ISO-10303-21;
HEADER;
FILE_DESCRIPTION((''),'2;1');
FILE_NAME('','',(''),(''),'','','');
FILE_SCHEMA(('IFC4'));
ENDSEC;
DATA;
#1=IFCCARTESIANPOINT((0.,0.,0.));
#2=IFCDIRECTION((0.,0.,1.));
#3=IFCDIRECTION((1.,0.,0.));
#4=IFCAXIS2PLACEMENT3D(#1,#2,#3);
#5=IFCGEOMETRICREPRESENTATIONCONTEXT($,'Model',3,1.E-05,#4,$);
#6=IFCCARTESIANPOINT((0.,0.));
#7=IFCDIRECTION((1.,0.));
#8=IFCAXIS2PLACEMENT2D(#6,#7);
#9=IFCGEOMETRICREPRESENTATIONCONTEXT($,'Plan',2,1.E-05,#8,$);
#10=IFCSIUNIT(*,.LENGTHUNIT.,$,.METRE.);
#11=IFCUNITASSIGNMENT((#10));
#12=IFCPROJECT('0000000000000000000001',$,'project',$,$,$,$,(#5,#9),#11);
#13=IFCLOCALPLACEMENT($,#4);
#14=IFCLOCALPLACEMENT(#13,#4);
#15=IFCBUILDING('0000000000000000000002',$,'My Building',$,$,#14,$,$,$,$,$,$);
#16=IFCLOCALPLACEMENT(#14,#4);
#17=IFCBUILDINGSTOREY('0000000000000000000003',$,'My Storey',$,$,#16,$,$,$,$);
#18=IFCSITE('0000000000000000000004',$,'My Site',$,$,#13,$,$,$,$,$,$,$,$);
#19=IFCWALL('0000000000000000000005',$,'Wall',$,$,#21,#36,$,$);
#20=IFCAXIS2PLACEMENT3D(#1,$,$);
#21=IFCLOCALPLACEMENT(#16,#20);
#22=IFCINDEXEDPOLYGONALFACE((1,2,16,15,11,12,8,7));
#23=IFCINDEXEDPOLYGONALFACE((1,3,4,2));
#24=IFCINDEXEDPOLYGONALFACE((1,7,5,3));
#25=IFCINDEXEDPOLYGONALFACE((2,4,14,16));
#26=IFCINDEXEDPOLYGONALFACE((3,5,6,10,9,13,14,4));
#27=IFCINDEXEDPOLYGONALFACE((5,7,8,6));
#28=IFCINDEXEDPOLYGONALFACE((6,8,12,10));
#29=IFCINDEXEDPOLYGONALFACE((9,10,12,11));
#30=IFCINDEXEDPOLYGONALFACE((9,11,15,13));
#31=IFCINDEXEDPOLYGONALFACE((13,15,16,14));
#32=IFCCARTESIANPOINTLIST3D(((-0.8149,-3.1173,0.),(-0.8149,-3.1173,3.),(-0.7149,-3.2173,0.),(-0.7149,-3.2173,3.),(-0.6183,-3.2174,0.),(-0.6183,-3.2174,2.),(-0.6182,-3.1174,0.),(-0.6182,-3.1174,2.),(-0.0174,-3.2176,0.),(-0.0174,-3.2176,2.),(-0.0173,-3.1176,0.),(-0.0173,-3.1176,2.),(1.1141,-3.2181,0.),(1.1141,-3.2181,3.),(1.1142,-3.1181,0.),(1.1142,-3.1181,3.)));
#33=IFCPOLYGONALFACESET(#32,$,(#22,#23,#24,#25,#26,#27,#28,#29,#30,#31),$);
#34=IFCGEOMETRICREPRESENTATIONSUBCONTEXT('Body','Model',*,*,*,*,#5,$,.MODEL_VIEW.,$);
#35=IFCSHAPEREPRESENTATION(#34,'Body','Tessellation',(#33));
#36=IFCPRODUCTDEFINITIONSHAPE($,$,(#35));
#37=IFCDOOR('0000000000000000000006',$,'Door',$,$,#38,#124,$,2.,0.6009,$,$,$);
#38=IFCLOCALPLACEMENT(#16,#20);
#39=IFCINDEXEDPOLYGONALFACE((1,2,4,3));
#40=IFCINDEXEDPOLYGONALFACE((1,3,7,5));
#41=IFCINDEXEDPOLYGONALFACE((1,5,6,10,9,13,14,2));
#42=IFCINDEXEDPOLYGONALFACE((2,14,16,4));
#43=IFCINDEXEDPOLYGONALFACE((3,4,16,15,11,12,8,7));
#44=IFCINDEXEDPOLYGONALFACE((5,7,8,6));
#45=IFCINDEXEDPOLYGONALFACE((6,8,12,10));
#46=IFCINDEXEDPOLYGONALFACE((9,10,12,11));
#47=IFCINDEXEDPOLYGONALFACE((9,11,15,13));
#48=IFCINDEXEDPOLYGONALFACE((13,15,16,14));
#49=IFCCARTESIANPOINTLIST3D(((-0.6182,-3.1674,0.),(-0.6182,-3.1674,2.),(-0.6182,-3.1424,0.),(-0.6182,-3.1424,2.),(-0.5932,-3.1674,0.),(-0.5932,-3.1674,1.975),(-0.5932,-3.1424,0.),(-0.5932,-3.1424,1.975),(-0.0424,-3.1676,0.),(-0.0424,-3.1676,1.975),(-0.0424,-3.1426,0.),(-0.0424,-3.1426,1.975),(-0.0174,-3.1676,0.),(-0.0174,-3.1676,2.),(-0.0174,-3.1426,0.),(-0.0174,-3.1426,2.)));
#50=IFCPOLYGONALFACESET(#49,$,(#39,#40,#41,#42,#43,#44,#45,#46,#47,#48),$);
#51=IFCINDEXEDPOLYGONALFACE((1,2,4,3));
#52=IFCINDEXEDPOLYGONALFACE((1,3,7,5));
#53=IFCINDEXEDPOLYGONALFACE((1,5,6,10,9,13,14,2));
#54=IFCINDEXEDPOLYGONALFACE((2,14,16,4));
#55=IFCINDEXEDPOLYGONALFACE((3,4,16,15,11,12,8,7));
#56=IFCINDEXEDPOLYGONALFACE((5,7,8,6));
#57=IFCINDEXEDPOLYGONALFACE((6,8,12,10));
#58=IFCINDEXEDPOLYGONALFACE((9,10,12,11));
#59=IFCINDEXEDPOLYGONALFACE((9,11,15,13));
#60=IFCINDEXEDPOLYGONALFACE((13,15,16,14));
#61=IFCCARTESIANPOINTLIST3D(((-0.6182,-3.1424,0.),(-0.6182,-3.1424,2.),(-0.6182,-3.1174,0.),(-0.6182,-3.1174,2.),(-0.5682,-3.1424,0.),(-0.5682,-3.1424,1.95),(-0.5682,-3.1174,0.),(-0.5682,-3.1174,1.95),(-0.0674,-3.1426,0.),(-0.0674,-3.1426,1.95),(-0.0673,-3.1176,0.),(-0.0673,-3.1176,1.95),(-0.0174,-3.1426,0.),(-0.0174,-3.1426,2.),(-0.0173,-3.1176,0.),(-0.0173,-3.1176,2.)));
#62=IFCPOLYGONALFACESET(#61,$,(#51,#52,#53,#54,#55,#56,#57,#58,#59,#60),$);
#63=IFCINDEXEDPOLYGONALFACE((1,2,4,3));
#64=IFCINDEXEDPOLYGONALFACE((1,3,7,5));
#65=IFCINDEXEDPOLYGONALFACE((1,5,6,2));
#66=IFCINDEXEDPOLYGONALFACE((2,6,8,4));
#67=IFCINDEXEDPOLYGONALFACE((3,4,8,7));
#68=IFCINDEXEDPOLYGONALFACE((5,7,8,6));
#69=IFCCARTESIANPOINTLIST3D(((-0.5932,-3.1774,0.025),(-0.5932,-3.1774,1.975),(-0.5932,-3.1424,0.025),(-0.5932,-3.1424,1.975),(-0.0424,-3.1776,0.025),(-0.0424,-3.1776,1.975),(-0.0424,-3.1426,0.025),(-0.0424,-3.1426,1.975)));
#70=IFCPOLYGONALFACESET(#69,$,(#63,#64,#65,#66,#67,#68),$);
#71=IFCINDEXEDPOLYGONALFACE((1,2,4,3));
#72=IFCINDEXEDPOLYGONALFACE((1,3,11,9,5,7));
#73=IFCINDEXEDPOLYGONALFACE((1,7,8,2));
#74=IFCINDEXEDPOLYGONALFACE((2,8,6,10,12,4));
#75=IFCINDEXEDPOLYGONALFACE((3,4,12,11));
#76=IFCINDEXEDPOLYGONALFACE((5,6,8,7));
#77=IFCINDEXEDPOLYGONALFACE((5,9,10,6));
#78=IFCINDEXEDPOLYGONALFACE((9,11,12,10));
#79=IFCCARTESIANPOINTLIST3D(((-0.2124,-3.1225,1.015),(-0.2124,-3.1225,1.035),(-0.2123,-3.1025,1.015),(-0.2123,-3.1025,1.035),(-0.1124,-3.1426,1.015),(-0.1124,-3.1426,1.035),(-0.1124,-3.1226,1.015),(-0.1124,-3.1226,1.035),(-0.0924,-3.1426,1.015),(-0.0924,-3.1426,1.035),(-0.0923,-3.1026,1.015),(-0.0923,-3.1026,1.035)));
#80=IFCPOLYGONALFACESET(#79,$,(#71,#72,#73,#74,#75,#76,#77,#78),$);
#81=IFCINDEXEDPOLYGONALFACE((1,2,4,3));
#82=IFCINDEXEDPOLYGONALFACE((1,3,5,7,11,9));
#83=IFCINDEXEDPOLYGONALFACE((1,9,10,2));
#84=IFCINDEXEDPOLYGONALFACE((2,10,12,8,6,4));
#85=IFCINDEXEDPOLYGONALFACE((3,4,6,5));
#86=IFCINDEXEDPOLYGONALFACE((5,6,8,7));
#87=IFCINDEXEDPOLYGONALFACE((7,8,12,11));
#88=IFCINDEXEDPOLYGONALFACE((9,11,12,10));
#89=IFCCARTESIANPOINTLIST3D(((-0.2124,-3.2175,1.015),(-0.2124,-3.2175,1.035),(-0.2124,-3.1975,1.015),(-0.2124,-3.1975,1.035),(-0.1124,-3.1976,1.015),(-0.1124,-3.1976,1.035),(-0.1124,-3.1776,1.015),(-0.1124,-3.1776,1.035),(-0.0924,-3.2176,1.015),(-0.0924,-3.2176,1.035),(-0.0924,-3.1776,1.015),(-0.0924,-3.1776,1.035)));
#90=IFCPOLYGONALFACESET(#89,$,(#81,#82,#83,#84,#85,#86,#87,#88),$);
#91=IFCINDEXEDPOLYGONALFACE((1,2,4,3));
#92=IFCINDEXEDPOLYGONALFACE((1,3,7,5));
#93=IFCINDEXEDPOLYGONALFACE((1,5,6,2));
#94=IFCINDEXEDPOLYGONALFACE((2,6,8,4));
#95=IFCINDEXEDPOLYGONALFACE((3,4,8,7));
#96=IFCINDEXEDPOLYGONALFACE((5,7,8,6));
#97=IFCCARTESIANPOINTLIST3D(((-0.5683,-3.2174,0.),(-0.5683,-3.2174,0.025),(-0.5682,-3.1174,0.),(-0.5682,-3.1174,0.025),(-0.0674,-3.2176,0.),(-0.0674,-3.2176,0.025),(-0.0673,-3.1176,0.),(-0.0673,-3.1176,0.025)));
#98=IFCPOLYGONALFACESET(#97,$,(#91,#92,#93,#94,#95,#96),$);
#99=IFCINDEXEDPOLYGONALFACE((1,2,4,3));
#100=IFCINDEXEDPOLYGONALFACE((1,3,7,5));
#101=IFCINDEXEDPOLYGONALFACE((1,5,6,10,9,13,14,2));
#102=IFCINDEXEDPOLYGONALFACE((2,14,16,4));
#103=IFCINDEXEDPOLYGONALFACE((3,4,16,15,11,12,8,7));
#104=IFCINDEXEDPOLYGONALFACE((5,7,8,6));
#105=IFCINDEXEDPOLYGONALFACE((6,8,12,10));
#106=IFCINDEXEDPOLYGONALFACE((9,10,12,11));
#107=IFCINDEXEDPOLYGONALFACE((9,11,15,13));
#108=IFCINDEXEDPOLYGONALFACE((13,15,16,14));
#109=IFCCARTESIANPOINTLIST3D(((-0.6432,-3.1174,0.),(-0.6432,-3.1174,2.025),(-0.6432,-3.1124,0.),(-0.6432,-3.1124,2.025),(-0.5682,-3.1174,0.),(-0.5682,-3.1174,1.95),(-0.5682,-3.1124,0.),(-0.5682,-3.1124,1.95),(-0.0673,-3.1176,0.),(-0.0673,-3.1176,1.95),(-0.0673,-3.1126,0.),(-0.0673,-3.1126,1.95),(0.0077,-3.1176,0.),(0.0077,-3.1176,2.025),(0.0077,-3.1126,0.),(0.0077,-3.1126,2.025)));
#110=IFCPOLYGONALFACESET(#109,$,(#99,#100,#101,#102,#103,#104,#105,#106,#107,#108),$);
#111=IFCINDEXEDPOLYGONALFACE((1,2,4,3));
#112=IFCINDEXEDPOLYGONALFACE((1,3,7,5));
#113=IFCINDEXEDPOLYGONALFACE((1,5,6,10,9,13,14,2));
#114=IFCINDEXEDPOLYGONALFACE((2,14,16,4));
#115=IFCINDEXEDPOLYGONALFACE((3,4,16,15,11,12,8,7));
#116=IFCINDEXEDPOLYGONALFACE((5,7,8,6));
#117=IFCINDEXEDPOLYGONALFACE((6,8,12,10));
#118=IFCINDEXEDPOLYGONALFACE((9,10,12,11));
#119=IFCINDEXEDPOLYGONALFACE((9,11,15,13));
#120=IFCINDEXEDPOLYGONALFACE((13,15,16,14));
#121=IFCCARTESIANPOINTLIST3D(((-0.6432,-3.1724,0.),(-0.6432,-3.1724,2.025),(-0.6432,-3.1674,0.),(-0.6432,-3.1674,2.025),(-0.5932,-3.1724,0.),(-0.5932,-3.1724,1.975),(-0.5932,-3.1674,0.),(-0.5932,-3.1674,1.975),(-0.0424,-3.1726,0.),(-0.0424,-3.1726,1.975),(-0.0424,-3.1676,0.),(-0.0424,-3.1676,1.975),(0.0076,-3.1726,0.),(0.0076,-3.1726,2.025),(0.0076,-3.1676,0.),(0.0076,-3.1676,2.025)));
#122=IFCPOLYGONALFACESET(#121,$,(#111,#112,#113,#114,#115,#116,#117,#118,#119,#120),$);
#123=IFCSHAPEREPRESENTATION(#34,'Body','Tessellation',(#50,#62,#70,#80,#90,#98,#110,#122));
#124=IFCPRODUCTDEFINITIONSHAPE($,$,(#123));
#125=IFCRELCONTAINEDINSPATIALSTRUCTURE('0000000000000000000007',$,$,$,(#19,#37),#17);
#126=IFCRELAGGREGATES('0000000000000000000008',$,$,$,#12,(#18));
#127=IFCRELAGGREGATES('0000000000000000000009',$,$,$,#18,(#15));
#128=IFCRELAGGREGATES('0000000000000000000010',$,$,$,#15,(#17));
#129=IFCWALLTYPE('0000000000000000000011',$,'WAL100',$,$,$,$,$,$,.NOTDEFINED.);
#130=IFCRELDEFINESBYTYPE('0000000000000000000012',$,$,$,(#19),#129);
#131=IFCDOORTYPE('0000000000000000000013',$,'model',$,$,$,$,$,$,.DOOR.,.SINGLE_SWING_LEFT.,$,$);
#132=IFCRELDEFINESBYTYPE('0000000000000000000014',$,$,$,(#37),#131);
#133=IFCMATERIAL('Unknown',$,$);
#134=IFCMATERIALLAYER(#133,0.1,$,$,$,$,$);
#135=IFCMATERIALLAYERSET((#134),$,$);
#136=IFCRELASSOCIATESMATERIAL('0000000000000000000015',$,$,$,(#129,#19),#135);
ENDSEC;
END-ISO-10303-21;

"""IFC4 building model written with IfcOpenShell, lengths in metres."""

from ifc_helpers import new_model, entity, si_unit, frame, origin_with_axes, origin_2d_with_axis, place, context, subcontext, project, spatial, line, indexed_curve, outline, extrude, shape, source, transform, mapped, material, layer, layer_set, layer_usage, type_object, type_shapes, element, fill, save


model = new_model("IFC4")

# Units and contexts
model_context = context("Model", 3, precision=1e-05, world=origin_with_axes())
plan_context = context("Plan", 2, precision=1e-05, world=origin_2d_with_axis())
body_context_1 = subcontext(model_context, "Body", "Model", "MODEL_VIEW")
body_context_2 = subcontext(plan_context, "Body", "Plan", "PLAN_VIEW")
ifc_project = project(units=[si_unit("LENGTHUNIT", "METRE")], contexts=[model_context, plan_context])

# Site, building, storey
site_placement = place(None, origin_with_axes())
site = spatial("IfcSite", under=ifc_project, at=site_placement, Name="My Site")
building_placement = place(site_placement, origin_with_axes())
building = spatial("IfcBuilding", under=site, at=building_placement, Name="My Building")
storey_placement = place(building_placement, origin_with_axes())
storey = spatial("IfcBuildingStorey", under=building, at=storey_placement, Name="My Storey")

# Shared definitions
ifc_material = material(Name="Unknown")

# Shared definitions
ifc_layer_1 = layer(ifc_material, 0.1)
ifc_layer_set_1 = layer_set([ifc_layer_1])
wall_type_1 = type_object("IfcWallType", Name="WAL100", PredefinedType="NOTDEFINED", material=ifc_layer_set_1)

# Wall, opening, door
ifc_layer_usage_1 = layer_usage(ifc_layer_set_1, "AXIS2", "POSITIVE", 0.0)
wall_1_placement = place(storey_placement, frame((-0.7149, -3.2173, 0.0), z_axis=(0.0, 0.0, 1.0), x_axis=(1.0, -0.000429, 0.0)))
wall_1 = element("IfcWall", 1, at=wall_1_placement, inside=storey, type_object=wall_type_1, material=ifc_layer_usage_1, Name="Wall", context=body_context_1, shape_type="SweptSolid", body=[
    extrude(outline(indexed_curve([(0.0, 0.0), (-0.1, 0.1), (1.829, 0.1), (1.829, 0.0)], segments=[line(1, 2, 3, 4, 1)])), origin_with_axes(), (0.0, 0.0, 1.0), 3.0),
])
shared_shape_1 = source(origin_with_axes(), body_context_1, "Body", "SweptSolid", [
    extrude(outline(indexed_curve([(0.0, 0.0), (0.6009, 0.0), (0.6009, 2.0), (0.0, 2.0)], segments=[line(1, 2, 3, 4, 1)])), frame((0.0, -0.6, 0.0), z_axis=(0.0, -1.0, 0.0), x_axis=(1.0, 0.0, 0.0)), (0.0, 0.0, -1.0), 1.2),
])
opening_1_placement = place(wall_1_placement, frame((0.6975, 0.1, 0.0), z_axis=(0.0, 0.0, 1.0), x_axis=(-1.0, 0.0, 0.0)))
opening_1 = element("IfcOpeningElement", 2, at=opening_1_placement, cuts=wall_1, PredefinedType="OPENING", context=body_context_1, shape_type="MappedRepresentation", body=[
    mapped(shared_shape_1, transform((0.0, 0.0, 0.0), x_axis=(1.0, 0.0, 0.0), y_axis=(0.0, 1.0, 0.0), z_axis=(0.0, 0.0, 1.0), scale=1.0)),
])
door_type_1 = type_object("IfcDoorType", Name="model", OperationType="SINGLE_SWING_LEFT", PredefinedType="DOOR")
shared_shape_2 = source(origin_with_axes(), body_context_1, "Body", "SweptSolid", [
    extrude(outline(indexed_curve([(0.0, 0.0), (0.0, 2.0), (0.6009, 2.0), (0.6009, 0.0), (0.5759, 0.0), (0.5759, 1.975), (0.025, 1.975), (0.025, 0.0)], segments=[line(1, 2, 3, 4, 5, 6, 7, 8, 1)])), frame((0.0, 0.025, 0.0), z_axis=(0.0, -1.0, 0.0), x_axis=(1.0, 0.0, 0.0)), (0.0, 0.0, -1.0), 0.025),
    extrude(outline(indexed_curve([(0.0, 0.0), (0.0, 2.0), (0.6009, 2.0), (0.6009, 0.0), (0.5509, 0.0), (0.5509, 1.95), (0.05, 1.95), (0.05, 0.0)], segments=[line(1, 2, 3, 4, 5, 6, 7, 8, 1)])), frame((0.0, 0.0, 0.0), z_axis=(0.0, -1.0, 0.0), x_axis=(1.0, 0.0, 0.0)), (0.0, 0.0, -1.0), 0.025),
    extrude(outline(indexed_curve([(0.0, 0.0), (0.5509, 0.0), (0.5509, 0.035), (0.0, 0.035)], segments=[line(1, 2, 3, 4, 1)])), frame((0.025, 0.025, 0.025), z_axis=(0.0, 0.0, 1.0), x_axis=(1.0, 0.0, 0.0)), (0.0, 0.0, 1.0), 1.95),
    extrude(outline(indexed_curve([(0.0, 0.0), (0.0, -0.04), (0.12, -0.04), (0.12, -0.02), (0.02, -0.02), (0.02, 0.0)], segments=[line(1, 2, 3, 4, 5, 6, 1)])), frame((0.075, 0.025, 1.015), z_axis=(0.0, 0.0, 1.0), x_axis=(1.0, 0.0, 0.0)), (0.0, 0.0, 1.0), 0.02),
    extrude(outline(indexed_curve([(0.0, 0.0), (0.0, 0.04), (0.12, 0.04), (0.12, 0.02), (0.02, 0.02), (0.02, 0.0)], segments=[line(1, 2, 3, 4, 5, 6, 1)])), frame((0.075, 0.06, 1.015), z_axis=(0.0, 0.0, 1.0), x_axis=(1.0, 0.0, 0.0)), (0.0, 0.0, 1.0), 0.02),
    extrude(outline(indexed_curve([(0.0, 0.0), (0.5009, 0.0), (0.5009, 0.1), (0.0, 0.1)], segments=[line(1, 2, 3, 4, 1)])), frame((0.05, 0.0, 0.0), z_axis=(0.0, 0.0, 1.0), x_axis=(1.0, 0.0, 0.0)), (0.0, 0.0, 1.0), 0.025),
    extrude(outline(indexed_curve([(0.0, 0.0), (0.0, 2.025), (0.6509, 2.025), (0.6509, 0.0), (0.5759, 0.0), (0.5759, 1.95), (0.075, 1.95), (0.075, 0.0)], segments=[line(1, 2, 3, 4, 5, 6, 7, 8, 1)])), frame((-0.025, -0.005, 0.0), z_axis=(0.0, -1.0, 0.0), x_axis=(1.0, 0.0, 0.0)), (0.0, 0.0, -1.0), 0.005),
    extrude(outline(indexed_curve([(0.0, 0.0), (0.0, 2.025), (0.6509, 2.025), (0.6509, 0.0), (0.6009, 0.0), (0.6009, 1.975), (0.05, 1.975), (0.05, 0.0)], segments=[line(1, 2, 3, 4, 5, 6, 7, 8, 1)])), frame((-0.025, 0.05, 0.0), z_axis=(0.0, -1.0, 0.0), x_axis=(1.0, 0.0, 0.0)), (0.0, 0.0, -1.0), 0.005),
])
shared_shape_3 = source(origin_with_axes(), body_context_2, "Body", "Curve2D", [
    entity("IfcIndexedPolyCurve", entity("IfcCartesianPointList2D", [[0.0, 0.0], [0.0, 0.05], [0.025, 0.05], [0.025, 0.025], [0.05, 0.025], [0.05, 0.0]]), [entity("IfcLineIndex", [1, 2, 3, 4, 5, 6, 1])]),
    entity("IfcIndexedPolyCurve", entity("IfcCartesianPointList2D", [[0.6009, 0.0], [0.6009, 0.05], [0.5759, 0.05], [0.5759, 0.025], [0.5509, 0.025], [0.5509, 0.0]]), [entity("IfcLineIndex", [1, 2, 3, 4, 5, 6, 1])]),
    entity("IfcTrimmedCurve", entity("IfcEllipse", entity("IfcAxis2Placement2D", entity("IfcCartesianPoint", [0.5409, 0.05]), entity("IfcDirection", [1.0, 0.0])), 0.5159, 0.5509), [entity("IfcCartesianPoint", [0.5409, 0.6009])], [entity("IfcCartesianPoint", [0.025, 0.05])], True, "CARTESIAN"),
    entity("IfcIndexedPolyCurve", entity("IfcCartesianPointList2D", [[0.5759, 0.05], [0.5409, 0.05], [0.5409, 0.6009], [0.5759, 0.6009]]), [entity("IfcLineIndex", [1, 2, 3, 4, 1])]),
])
type_shapes(door_type_1, [shared_shape_2, shared_shape_3])
door_1_placement = place(opening_1_placement, frame((0.0, 0.0, 0.0), z_axis=(0.0, 0.0, 1.0), x_axis=(1.0, 0.0, 0.0)))
door_1 = element("IfcDoor", 3, at=door_1_placement, inside=storey, type_object=door_type_1, Name="Door", OverallHeight=2.0, OverallWidth=0.6009, shapes=[
    shape(body_context_1, "Body", "MappedRepresentation", [mapped(shared_shape_2, transform((0.0, 0.0, 0.0), x_axis=(1.0, 0.0, 0.0), y_axis=(0.0, 1.0, 0.0), z_axis=(0.0, 0.0, 1.0), scale=1.0))]),
    shape(body_context_2, "Body", "MappedRepresentation", [mapped(shared_shape_3, transform((0.0, 0.0, 0.0), x_axis=(1.0, 0.0, 0.0), y_axis=(0.0, 1.0, 0.0), z_axis=(0.0, 0.0, 1.0), scale=1.0))]),
])
fill(opening_1, door_1)

save(model, "model.ifc")
